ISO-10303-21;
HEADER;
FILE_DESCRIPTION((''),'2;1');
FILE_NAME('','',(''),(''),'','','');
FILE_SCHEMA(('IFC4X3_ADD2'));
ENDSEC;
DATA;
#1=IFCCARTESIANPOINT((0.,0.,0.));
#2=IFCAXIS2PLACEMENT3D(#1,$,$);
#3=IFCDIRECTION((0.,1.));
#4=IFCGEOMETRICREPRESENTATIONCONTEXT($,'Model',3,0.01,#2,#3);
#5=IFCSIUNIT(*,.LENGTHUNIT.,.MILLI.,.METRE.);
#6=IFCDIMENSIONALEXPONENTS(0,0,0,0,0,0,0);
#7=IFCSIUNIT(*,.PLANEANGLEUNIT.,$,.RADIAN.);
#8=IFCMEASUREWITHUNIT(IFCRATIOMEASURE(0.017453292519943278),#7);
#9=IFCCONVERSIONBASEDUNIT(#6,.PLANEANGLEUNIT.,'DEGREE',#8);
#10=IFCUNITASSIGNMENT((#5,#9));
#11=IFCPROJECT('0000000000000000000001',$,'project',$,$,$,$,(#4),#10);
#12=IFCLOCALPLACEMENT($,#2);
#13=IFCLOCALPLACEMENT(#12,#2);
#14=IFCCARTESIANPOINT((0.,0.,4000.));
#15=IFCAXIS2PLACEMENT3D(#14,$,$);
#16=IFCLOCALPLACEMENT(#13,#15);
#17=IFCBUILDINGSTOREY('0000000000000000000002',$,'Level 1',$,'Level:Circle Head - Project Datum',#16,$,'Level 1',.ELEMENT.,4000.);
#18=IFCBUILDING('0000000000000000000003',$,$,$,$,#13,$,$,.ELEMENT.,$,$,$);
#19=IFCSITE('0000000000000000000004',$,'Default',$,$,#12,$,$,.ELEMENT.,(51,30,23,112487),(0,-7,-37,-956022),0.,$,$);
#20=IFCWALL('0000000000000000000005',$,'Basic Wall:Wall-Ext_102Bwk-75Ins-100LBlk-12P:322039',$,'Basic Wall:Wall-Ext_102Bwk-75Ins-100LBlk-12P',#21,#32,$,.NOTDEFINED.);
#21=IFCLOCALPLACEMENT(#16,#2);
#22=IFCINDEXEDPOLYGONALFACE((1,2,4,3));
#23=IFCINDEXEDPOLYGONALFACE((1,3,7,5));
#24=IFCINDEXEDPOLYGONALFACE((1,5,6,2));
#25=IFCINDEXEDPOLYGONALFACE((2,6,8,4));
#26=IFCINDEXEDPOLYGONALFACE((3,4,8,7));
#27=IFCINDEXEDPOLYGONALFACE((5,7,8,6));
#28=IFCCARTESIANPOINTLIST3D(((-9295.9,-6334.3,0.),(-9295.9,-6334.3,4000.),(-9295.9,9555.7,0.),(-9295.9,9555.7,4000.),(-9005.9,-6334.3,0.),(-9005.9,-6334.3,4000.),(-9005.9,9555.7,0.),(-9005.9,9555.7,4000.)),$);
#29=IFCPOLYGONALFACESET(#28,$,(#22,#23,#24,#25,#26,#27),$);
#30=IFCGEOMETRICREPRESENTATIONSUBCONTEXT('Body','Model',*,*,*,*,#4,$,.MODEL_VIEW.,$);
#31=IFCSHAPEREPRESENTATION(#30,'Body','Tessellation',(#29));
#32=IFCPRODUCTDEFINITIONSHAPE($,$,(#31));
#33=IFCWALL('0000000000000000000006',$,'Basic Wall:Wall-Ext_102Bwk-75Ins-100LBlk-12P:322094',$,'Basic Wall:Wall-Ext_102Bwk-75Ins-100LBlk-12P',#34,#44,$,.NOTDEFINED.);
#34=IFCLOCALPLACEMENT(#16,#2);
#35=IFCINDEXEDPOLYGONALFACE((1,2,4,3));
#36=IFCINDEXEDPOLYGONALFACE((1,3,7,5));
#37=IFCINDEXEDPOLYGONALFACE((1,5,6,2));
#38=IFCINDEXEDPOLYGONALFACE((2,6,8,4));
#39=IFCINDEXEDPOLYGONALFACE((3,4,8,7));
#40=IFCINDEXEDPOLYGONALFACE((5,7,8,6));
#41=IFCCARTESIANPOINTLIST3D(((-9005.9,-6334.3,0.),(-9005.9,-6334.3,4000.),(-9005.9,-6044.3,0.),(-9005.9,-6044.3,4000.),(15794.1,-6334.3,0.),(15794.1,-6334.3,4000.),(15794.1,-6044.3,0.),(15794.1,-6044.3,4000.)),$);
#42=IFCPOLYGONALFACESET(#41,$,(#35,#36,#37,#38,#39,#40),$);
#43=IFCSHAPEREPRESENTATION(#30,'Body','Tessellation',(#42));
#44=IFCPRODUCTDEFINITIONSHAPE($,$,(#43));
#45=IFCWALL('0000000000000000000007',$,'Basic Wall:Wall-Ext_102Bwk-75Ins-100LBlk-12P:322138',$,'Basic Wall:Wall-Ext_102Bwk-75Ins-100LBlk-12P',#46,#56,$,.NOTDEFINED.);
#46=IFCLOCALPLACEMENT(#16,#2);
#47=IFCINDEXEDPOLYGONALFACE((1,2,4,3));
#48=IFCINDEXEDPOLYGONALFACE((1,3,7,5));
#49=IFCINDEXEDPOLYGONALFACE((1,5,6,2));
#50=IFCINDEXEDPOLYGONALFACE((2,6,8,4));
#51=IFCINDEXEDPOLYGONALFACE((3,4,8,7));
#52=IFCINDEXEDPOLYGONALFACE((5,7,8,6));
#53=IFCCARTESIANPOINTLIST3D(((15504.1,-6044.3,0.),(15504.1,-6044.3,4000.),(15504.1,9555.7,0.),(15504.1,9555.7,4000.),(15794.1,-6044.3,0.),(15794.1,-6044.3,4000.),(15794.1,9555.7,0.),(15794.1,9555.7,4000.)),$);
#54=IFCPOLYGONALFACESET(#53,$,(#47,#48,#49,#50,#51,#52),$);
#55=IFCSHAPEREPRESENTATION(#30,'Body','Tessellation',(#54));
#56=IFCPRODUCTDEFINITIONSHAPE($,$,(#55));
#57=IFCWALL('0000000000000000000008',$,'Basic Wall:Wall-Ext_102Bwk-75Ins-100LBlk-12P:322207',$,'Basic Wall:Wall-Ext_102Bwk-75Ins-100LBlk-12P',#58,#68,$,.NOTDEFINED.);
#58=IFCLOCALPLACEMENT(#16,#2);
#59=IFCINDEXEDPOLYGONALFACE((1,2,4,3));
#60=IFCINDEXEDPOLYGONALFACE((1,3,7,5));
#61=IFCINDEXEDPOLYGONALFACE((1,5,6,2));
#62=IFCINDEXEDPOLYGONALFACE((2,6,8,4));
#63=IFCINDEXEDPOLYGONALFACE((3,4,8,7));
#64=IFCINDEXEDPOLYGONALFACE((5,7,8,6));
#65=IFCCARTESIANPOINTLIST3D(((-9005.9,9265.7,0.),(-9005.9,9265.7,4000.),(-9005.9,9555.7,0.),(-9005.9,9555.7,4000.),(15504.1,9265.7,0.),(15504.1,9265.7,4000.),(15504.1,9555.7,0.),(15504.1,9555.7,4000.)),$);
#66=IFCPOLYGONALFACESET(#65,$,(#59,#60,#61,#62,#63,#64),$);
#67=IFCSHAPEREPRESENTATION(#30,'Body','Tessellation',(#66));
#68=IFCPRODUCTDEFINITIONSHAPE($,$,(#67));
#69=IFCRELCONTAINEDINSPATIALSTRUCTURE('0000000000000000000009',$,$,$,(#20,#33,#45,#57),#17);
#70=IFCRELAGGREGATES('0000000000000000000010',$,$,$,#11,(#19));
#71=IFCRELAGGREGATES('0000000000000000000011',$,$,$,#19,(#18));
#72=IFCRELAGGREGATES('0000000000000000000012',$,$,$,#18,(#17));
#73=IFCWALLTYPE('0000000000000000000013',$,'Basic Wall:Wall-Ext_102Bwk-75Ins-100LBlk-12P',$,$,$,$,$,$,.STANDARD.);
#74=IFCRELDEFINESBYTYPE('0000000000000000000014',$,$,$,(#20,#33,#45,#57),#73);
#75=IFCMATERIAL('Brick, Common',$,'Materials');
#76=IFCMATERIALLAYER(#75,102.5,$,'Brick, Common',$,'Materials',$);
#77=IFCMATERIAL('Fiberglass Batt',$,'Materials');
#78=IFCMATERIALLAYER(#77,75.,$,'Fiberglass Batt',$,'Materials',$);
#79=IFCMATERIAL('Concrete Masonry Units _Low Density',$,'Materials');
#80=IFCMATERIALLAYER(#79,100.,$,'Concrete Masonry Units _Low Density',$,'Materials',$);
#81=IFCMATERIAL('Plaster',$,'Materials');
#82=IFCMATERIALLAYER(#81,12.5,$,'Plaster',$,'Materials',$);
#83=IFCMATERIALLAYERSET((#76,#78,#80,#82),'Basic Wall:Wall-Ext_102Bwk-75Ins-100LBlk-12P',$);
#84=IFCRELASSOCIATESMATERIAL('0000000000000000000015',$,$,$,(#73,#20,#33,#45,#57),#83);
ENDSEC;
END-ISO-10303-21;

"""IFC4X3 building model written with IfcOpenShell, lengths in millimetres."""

from ifc_helpers import new_model, entity, si_unit, converted_unit, direction, frame, frame_2d, origin, place, context, subcontext, project, spatial, rectangle, extrude, clip, halfspace, material, layer, layer_set, type_object, element, save


model = new_model("IFC4X3")

# Units and contexts
model_context = context("Model", 3, precision=0.01, world=origin(), true_north=direction((0.0, 1.0)))
body_context = subcontext(model_context, "Body", "Model", "MODEL_VIEW")
ifc_project = project(units=[si_unit("LENGTHUNIT", "METRE", prefix="MILLI"), converted_unit("PLANEANGLEUNIT", "DEGREE", entity("IfcRatioMeasure", 0.017453292519943278), si_unit("PLANEANGLEUNIT", "RADIAN"), dimensions=[0, 0, 0, 0, 0, 0, 0])], contexts=[model_context])

# Site, building, storey
site_placement = place(None, origin())
site = spatial("IfcSite", under=ifc_project, at=site_placement, Name="Default", CompositionType="ELEMENT", RefLatitude=(51, 30, 23, 112487), RefLongitude=(0, -7, -37, -956022), RefElevation=0.0)
building_placement = place(site_placement, origin())
building = spatial("IfcBuilding", under=site, at=building_placement, CompositionType="ELEMENT")
storey_placement = place(building_placement, frame((0.0, 0.0, 4000.0)))
storey = spatial("IfcBuildingStorey", under=building, at=storey_placement, Name="Level 1", ObjectType="Level:Circle Head - Project Datum", LongName="Level 1", CompositionType="ELEMENT", Elevation=4000.0)

# Walls
ifc_material_1 = material(Name="Brick, Common", Category="Materials")
ifc_layer_1 = layer(ifc_material_1, 102.5, Name="Brick, Common", Category="Materials")
ifc_material_2 = material(Name="Fiberglass Batt", Category="Materials")
ifc_layer_2 = layer(ifc_material_2, 75.0, Name="Fiberglass Batt", Category="Materials")
ifc_material_3 = material(Name="Concrete Masonry Units _Low Density", Category="Materials")
ifc_layer_3 = layer(ifc_material_3, 100.0, Name="Concrete Masonry Units _Low Density", Category="Materials")
ifc_material_4 = material(Name="Plaster", Category="Materials")
ifc_layer_4 = layer(ifc_material_4, 12.5, Name="Plaster", Category="Materials")
ifc_layer_set = layer_set([ifc_layer_1, ifc_layer_2, ifc_layer_3, ifc_layer_4], Name="Basic Wall:Wall-Ext_102Bwk-75Ins-100LBlk-12P")
wall_type = type_object("IfcWallType", Name="Basic Wall:Wall-Ext_102Bwk-75Ins-100LBlk-12P", PredefinedType="STANDARD", material=ifc_layer_set)
wall_1_placement = place(storey_placement, frame((-9150.9, 9555.7, 0.0), z_axis=(0.0, 0.0, 1.0), x_axis=(0.0, -1.0, 0.0)))
element("IfcWall", 1, at=wall_1_placement, inside=storey, type_object=wall_type, material=ifc_layer_set, Name="Basic Wall:Wall-Ext_102Bwk-75Ins-100LBlk-12P:322039", ObjectType="Basic Wall:Wall-Ext_102Bwk-75Ins-100LBlk-12P", PredefinedType="NOTDEFINED", context=body_context, shape_type="Clipping", body=[
    clip(extrude(rectangle(XDim=15890.0, YDim=290.0, at=frame_2d((7945.0, 0.0), x_axis=(-1.0, 0.0))), origin(), (0.0, 0.0, 1.0), 4000.0), halfspace(frame((0.0, 0.0, -4000.0)), True)),
])
wall_2_placement = place(storey_placement, frame((-9005.9, -6189.3, 0.0)))
element("IfcWall", 2, at=wall_2_placement, inside=storey, type_object=wall_type, material=ifc_layer_set, Name="Basic Wall:Wall-Ext_102Bwk-75Ins-100LBlk-12P:322094", ObjectType="Basic Wall:Wall-Ext_102Bwk-75Ins-100LBlk-12P", PredefinedType="NOTDEFINED", context=body_context, shape_type="Clipping", body=[
    clip(extrude(rectangle(XDim=24800.0, YDim=290.0, at=frame_2d((12400.0, 0.0), x_axis=(-1.0, 0.0))), origin(), (0.0, 0.0, 1.0), 4000.0), halfspace(frame((0.0, 0.0, -4000.0)), True)),
])
wall_3_placement = place(storey_placement, frame((15649.1, -6044.3, 0.0), z_axis=(0.0, 0.0, 1.0), x_axis=(0.0, 1.0, 0.0)))
element("IfcWall", 3, at=wall_3_placement, inside=storey, type_object=wall_type, material=ifc_layer_set, Name="Basic Wall:Wall-Ext_102Bwk-75Ins-100LBlk-12P:322138", ObjectType="Basic Wall:Wall-Ext_102Bwk-75Ins-100LBlk-12P", PredefinedType="NOTDEFINED", context=body_context, shape_type="Clipping", body=[
    clip(extrude(rectangle(XDim=15600.0, YDim=290.0, at=frame_2d((7800.0, 0.0), x_axis=(-1.0, 0.0))), origin(), (0.0, 0.0, 1.0), 4000.0), halfspace(frame((0.0, 0.0, -4000.0)), True)),
])
wall_4_placement = place(storey_placement, frame((15504.1, 9410.7, 0.0), z_axis=(0.0, 0.0, 1.0), x_axis=(-1.0, 0.0, 0.0)))
element("IfcWall", 4, at=wall_4_placement, inside=storey, type_object=wall_type, material=ifc_layer_set, Name="Basic Wall:Wall-Ext_102Bwk-75Ins-100LBlk-12P:322207", ObjectType="Basic Wall:Wall-Ext_102Bwk-75Ins-100LBlk-12P", PredefinedType="NOTDEFINED", context=body_context, shape_type="Clipping", body=[
    clip(extrude(rectangle(XDim=24510.0, YDim=290.0, at=frame_2d((12255.0, 0.0), x_axis=(-1.0, 0.0))), origin(), (0.0, 0.0, 1.0), 4000.0), halfspace(frame((0.0, 0.0, -4000.0)), True)),
])

save(model, "model.ifc")
